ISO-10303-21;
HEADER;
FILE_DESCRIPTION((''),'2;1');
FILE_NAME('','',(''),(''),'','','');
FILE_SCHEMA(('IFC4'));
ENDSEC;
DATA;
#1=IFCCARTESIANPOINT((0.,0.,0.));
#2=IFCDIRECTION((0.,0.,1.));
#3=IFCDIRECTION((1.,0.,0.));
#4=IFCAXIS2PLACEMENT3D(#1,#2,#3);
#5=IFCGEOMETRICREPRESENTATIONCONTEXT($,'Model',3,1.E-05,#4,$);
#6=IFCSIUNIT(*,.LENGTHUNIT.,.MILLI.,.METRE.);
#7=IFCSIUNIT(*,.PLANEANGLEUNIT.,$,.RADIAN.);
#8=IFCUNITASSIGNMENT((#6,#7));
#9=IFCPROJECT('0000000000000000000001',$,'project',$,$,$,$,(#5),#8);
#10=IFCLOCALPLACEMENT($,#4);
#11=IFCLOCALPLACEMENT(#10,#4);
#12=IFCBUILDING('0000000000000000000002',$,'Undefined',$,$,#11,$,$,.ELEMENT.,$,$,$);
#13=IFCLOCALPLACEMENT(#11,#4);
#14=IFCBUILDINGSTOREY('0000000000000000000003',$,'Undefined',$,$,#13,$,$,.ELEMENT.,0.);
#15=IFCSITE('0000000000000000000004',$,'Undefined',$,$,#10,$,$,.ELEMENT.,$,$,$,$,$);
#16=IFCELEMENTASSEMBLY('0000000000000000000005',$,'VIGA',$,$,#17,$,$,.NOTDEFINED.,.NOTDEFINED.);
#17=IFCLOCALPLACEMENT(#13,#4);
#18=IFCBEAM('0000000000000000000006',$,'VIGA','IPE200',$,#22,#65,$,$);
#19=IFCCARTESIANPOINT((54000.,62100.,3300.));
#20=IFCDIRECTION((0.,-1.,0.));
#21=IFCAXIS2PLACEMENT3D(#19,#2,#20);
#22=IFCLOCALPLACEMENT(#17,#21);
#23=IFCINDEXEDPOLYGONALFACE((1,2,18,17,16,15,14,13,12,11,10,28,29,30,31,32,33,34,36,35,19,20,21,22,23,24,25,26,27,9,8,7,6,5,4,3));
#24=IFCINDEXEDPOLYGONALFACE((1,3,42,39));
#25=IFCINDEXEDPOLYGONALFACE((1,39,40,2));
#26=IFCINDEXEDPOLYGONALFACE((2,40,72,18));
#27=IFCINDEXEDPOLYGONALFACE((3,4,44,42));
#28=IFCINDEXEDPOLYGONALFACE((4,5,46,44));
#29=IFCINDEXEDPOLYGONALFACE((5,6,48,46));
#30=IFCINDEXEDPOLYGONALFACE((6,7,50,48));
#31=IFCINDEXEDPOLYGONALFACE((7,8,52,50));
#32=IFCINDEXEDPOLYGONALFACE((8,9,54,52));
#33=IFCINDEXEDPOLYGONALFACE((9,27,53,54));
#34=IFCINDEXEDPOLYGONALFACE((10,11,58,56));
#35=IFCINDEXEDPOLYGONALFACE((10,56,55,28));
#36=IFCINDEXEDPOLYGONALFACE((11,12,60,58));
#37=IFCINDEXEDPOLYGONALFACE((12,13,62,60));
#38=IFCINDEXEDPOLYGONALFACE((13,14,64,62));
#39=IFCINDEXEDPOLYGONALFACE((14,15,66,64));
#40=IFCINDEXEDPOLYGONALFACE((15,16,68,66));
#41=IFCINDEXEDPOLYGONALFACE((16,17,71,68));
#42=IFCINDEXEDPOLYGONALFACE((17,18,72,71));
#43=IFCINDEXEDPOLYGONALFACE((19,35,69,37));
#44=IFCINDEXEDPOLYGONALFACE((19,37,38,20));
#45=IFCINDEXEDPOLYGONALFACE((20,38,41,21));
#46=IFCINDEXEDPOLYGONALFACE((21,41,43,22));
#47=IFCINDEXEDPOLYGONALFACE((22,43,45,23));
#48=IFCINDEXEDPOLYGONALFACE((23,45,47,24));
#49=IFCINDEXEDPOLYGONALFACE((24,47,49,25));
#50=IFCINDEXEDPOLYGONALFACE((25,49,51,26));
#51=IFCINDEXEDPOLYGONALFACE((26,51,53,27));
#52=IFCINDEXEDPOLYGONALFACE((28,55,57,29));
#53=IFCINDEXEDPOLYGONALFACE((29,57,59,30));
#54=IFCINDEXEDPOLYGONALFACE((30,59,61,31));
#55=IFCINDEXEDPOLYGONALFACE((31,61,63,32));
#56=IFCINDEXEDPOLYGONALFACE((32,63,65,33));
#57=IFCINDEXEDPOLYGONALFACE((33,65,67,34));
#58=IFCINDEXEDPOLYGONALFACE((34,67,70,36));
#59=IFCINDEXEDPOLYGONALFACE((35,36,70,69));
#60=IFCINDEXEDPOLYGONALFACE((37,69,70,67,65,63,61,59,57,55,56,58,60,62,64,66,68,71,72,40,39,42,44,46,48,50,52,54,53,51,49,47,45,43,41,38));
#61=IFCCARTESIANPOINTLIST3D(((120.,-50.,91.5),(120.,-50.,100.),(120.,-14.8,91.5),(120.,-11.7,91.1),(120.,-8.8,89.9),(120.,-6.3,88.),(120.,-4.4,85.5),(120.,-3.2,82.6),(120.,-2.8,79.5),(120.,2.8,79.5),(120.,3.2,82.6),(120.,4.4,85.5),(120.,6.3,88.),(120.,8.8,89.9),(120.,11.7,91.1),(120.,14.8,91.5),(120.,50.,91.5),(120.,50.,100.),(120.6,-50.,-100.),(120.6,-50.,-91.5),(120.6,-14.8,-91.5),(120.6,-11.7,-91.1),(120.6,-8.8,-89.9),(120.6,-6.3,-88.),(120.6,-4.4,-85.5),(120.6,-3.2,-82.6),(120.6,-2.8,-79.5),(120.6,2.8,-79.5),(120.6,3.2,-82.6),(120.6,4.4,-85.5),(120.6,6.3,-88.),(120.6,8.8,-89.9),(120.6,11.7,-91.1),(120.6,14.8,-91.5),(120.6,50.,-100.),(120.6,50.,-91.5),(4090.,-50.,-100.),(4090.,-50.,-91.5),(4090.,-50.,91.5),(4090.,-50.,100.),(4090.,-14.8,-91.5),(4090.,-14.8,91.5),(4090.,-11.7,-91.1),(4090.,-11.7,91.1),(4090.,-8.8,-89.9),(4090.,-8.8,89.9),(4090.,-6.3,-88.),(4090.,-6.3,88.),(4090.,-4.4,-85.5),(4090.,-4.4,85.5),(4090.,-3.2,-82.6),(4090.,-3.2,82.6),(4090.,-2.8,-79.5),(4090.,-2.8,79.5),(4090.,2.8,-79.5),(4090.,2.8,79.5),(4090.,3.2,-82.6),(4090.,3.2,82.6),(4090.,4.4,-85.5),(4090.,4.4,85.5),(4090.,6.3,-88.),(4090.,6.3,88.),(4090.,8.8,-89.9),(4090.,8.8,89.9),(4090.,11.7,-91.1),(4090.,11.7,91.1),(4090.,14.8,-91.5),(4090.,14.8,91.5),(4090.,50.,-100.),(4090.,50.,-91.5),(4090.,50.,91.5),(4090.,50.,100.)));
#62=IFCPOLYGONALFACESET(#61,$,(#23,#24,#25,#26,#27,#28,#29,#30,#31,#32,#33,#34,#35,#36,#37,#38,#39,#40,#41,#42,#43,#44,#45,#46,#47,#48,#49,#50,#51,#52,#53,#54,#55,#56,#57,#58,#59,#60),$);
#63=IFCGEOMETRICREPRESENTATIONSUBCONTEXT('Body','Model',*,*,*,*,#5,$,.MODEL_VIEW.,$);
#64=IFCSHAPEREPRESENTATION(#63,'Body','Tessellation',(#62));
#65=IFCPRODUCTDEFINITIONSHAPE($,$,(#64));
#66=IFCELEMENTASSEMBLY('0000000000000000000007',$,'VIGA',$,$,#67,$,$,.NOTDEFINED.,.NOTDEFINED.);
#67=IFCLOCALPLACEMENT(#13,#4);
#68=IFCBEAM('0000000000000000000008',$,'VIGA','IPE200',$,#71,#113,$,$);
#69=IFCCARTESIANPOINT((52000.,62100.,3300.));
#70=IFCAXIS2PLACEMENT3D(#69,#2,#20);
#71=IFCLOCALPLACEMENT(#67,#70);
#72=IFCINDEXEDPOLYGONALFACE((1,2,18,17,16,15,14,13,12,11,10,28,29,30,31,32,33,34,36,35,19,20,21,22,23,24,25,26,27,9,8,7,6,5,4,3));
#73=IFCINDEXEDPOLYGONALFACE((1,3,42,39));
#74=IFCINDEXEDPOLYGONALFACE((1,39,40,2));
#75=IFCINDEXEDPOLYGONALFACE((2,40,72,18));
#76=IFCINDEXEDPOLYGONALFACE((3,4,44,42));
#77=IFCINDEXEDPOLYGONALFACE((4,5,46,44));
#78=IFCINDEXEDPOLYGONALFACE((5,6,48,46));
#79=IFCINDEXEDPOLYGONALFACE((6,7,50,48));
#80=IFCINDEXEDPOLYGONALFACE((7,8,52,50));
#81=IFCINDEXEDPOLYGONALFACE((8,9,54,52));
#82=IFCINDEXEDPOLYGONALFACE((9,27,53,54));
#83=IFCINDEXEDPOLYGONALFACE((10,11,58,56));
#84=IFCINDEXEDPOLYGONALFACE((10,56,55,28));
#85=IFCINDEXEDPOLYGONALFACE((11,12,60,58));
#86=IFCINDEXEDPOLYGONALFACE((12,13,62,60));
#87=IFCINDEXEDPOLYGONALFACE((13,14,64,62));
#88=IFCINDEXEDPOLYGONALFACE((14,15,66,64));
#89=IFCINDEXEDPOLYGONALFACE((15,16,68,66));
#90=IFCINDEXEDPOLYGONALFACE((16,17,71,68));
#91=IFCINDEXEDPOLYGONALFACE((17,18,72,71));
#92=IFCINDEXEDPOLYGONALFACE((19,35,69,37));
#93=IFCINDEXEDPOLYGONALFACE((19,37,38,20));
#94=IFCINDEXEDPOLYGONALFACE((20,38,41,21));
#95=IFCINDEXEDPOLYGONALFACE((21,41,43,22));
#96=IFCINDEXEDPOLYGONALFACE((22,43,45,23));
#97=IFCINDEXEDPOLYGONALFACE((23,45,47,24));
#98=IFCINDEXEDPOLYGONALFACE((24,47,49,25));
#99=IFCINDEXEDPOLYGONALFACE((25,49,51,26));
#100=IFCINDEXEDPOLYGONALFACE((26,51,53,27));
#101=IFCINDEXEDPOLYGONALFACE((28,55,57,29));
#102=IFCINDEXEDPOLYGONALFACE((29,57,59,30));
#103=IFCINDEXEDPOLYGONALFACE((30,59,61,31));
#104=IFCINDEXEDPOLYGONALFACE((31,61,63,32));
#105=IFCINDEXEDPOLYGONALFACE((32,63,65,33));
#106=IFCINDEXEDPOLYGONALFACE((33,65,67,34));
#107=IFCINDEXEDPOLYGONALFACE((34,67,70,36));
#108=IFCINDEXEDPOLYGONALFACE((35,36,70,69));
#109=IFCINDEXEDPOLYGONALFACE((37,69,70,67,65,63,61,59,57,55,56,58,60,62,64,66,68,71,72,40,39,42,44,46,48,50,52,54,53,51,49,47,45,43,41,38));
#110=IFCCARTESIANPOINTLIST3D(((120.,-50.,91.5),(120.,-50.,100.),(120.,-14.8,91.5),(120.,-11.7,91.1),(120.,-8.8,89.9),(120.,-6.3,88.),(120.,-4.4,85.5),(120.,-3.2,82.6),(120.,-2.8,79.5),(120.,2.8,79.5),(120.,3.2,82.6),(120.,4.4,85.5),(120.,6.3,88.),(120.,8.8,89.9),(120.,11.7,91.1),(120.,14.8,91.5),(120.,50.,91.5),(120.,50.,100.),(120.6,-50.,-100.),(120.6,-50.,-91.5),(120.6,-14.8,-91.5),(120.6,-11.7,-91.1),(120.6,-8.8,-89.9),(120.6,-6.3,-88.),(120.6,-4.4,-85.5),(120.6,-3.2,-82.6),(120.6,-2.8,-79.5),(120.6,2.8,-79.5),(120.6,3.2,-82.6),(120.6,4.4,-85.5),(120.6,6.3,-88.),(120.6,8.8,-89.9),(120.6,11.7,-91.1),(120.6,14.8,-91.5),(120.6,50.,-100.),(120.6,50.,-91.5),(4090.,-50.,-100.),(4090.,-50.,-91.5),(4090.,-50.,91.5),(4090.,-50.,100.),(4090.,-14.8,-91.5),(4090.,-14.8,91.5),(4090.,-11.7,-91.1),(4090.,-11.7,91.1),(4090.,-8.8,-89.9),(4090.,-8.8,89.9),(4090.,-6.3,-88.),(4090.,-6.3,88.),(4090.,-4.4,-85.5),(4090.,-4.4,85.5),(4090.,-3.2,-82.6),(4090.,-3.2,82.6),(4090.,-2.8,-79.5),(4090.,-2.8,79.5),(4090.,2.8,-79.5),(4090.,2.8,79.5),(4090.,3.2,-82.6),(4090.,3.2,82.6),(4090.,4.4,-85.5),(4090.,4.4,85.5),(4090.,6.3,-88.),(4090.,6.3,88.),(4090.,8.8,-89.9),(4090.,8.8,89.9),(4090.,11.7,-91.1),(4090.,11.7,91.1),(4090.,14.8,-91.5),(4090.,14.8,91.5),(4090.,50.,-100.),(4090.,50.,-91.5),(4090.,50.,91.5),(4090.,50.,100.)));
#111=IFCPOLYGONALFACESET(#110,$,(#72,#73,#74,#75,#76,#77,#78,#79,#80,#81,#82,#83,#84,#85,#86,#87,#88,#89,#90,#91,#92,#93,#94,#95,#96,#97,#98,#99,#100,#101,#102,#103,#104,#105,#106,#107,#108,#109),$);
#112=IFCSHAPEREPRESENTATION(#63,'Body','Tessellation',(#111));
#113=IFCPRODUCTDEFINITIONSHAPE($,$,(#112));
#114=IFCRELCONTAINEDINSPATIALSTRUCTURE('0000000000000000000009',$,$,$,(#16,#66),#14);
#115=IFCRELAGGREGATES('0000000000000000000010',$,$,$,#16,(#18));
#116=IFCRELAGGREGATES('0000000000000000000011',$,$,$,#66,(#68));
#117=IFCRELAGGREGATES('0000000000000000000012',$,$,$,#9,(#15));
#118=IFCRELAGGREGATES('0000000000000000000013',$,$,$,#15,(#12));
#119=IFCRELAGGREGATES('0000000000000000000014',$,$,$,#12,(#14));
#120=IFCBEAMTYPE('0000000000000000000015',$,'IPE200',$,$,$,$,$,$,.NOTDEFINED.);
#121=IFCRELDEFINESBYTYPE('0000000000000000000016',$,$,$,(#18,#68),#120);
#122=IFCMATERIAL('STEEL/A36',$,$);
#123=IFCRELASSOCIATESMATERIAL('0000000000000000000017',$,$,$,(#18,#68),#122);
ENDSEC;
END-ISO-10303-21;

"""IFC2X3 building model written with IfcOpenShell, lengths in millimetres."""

from ifc_helpers import new_model, si_unit, frame, origin_with_axes, origin_2d_with_axis, place, context, subcontext, project, spatial, i_section, extrude, clip, halfspace, material, type_object, element, aggregate, save


model = new_model("IFC2X3")

# Units and contexts
model_context = context("Model", 3, precision=1e-05, world=origin_with_axes())
body_context = subcontext(model_context, "Body", "Model", "MODEL_VIEW")
ifc_project = project(units=[si_unit("LENGTHUNIT", "METRE", prefix="MILLI"), si_unit("PLANEANGLEUNIT", "RADIAN")], contexts=[model_context])

# Site, building, storey
site_placement = place(None, origin_with_axes())
site = spatial("IfcSite", under=ifc_project, at=site_placement, Name="Undefined", CompositionType="ELEMENT")
building_placement = place(site_placement, origin_with_axes())
building = spatial("IfcBuilding", under=site, at=building_placement, Name="Undefined", CompositionType="ELEMENT")
storey_placement = place(building_placement, origin_with_axes())
storey = spatial("IfcBuildingStorey", under=building, at=storey_placement, Name="Undefined", CompositionType="ELEMENT", Elevation=0.0)

# Shared definitions
ifc_material_1 = material(Name="STEEL/A36")

# Element assemblies, beams
assembly_1_placement = place(storey_placement, origin_with_axes())
assembly_1 = element("IfcElementAssembly", 1, at=assembly_1_placement, inside=storey, Name="VIGA", AssemblyPlace="NOTDEFINED", PredefinedType="NOTDEFINED")
beam_type_1 = type_object("IfcBeamType", Name="IPE200", PredefinedType="NOTDEFINED")
beam_1_placement = place(assembly_1_placement, frame((54000.0, 62100.0, 3300.0), z_axis=(0.0, 0.0, 1.0), x_axis=(0.0, -1.0, 0.0)))
beam_1 = element("IfcBeam", 2, at=beam_1_placement, type_object=beam_type_1, material=ifc_material_1, Name="VIGA", Description="IPE200", context=body_context, shape_type="Clipping", body=[
    clip(clip(extrude(i_section(OverallWidth=100.0, OverallDepth=200.0, WebThickness=5.6, FlangeThickness=8.5, FilletRadius=12.0, at=origin_2d_with_axis()), frame((4200.0, 0.0, 0.0), z_axis=(-1.0, 0.0, 0.0), x_axis=(0.0, -1.0, 0.0)), (0.0, 0.0, 1.0), 4200.0), halfspace(frame((4090.0, -400.0, 200.0), z_axis=(1.0, 0.0, 0.0), x_axis=(0.0, 1.0, 0.0)), False)), halfspace(frame((120.0, 0.0, 100.0), z_axis=(-0.999995, 0.0, -0.003301), x_axis=(0.0, -1.0, 0.0)), False)),
])
assembly_2_placement = place(storey_placement, origin_with_axes())
assembly_2 = element("IfcElementAssembly", 3, at=assembly_2_placement, inside=storey, Name="VIGA", AssemblyPlace="NOTDEFINED", PredefinedType="NOTDEFINED")
beam_2_placement = place(assembly_2_placement, frame((52000.0, 62100.0, 3300.0), z_axis=(0.0, 0.0, 1.0), x_axis=(0.0, -1.0, 0.0)))
beam_2 = element("IfcBeam", 4, at=beam_2_placement, type_object=beam_type_1, material=ifc_material_1, Name="VIGA", Description="IPE200", context=body_context, shape_type="Clipping", body=[
    clip(clip(extrude(i_section(OverallWidth=100.0, OverallDepth=200.0, WebThickness=5.6, FlangeThickness=8.5, FilletRadius=12.0, at=origin_2d_with_axis()), frame((4200.0, 0.0, 0.0), z_axis=(-1.0, 0.0, 0.0), x_axis=(0.0, -1.0, 0.0)), (0.0, 0.0, 1.0), 4200.0), halfspace(frame((4090.0, -400.0, 200.0), z_axis=(1.0, 0.0, 0.0), x_axis=(0.0, 1.0, 0.0)), False)), halfspace(frame((120.0, 0.0, 100.0), z_axis=(-0.999995, 0.0, -0.003301), x_axis=(0.0, -1.0, 0.0)), False)),
])

aggregate(assembly_1, [beam_1])
aggregate(assembly_2, [beam_2])

save(model, "model.ifc")
